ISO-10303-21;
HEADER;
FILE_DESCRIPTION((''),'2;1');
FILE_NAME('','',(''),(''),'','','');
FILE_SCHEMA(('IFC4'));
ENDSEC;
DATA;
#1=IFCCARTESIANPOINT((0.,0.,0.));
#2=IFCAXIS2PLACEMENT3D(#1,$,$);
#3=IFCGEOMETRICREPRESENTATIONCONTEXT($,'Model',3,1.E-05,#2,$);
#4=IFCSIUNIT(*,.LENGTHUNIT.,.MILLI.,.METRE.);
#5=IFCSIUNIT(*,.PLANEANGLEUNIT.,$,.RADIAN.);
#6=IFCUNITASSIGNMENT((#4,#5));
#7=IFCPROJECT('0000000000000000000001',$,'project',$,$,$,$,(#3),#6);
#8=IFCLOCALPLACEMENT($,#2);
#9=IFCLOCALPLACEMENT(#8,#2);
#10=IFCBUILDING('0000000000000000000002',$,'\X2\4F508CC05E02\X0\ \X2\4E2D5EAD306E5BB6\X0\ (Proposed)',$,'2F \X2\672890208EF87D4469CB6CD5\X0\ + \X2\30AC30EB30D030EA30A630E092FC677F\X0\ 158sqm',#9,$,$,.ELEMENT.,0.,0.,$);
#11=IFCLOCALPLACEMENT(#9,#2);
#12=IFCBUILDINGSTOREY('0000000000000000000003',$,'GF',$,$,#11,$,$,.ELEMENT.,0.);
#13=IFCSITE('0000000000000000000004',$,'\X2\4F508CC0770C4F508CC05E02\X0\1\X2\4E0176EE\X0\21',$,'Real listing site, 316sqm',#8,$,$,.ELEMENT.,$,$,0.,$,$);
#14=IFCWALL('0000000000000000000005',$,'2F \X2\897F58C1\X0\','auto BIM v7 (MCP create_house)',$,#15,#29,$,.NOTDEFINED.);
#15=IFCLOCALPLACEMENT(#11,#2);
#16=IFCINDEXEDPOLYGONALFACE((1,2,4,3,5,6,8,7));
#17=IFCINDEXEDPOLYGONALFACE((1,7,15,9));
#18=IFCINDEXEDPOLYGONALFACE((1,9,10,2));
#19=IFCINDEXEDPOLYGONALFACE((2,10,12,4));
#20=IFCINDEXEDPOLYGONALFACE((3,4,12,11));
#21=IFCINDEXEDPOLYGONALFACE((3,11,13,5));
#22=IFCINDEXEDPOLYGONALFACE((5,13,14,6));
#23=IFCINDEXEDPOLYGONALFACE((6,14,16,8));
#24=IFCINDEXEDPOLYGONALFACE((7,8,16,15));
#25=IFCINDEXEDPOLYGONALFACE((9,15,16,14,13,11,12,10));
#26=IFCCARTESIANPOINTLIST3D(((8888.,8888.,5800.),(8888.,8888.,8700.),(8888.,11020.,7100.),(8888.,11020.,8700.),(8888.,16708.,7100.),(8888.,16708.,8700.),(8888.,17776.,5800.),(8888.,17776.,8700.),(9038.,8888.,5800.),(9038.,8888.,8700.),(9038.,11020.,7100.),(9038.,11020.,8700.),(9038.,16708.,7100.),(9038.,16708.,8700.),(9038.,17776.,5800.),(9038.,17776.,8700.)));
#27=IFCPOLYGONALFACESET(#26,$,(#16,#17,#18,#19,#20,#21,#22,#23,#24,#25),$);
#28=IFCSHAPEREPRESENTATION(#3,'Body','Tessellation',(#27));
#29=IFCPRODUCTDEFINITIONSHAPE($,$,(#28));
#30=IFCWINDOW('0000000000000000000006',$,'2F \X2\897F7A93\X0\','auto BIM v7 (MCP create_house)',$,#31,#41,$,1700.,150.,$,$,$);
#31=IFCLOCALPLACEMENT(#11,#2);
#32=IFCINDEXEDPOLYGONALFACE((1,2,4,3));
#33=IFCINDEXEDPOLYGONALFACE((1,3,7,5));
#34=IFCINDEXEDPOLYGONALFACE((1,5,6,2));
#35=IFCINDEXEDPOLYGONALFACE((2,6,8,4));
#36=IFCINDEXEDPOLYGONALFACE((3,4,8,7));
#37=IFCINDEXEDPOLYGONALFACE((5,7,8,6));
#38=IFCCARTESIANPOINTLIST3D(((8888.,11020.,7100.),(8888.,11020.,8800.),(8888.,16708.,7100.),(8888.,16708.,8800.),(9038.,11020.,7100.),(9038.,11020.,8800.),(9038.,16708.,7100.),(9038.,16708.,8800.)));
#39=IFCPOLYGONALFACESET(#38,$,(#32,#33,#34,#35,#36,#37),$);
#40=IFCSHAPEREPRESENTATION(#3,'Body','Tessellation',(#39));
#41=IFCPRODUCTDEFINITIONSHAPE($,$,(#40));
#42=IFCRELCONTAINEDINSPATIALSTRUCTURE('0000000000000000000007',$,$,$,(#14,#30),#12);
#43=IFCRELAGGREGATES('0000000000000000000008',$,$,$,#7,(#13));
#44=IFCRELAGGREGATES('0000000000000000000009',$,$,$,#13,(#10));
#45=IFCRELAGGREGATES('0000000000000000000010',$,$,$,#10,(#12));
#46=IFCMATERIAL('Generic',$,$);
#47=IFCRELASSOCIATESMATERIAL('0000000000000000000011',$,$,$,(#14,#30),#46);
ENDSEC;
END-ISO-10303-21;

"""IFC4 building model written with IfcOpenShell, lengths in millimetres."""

from ifc_helpers import new_model, si_unit, frame, frame_2d, origin, place, context, project, spatial, rectangle, extrude, material, element, fill, save


model = new_model("IFC4")

# Units and contexts
model_context = context("Model", 3, precision=1e-05, world=origin())
ifc_project = project(units=[si_unit("LENGTHUNIT", "METRE", prefix="MILLI"), si_unit("PLANEANGLEUNIT", "RADIAN")], contexts=[model_context])

# Site, building, storey
site_placement = place(None, origin())
site = spatial("IfcSite", under=ifc_project, at=site_placement, Name="佐賀県佐賀市1丁目21", ObjectType="Real listing site, 316sqm", CompositionType="ELEMENT", RefElevation=0.0)
building_placement = place(site_placement, origin())
building = spatial("IfcBuilding", under=site, at=building_placement, Name="佐賀市 中庭の家 (Proposed)", ObjectType="2F 木造軸組構法 + ガルバリウム鋼板 158sqm", CompositionType="ELEMENT", ElevationOfRefHeight=0.0, ElevationOfTerrain=0.0)
storey_placement = place(building_placement, origin())
storey = spatial("IfcBuildingStorey", under=building, at=storey_placement, Name="GF", CompositionType="ELEMENT", Elevation=0.0)

# Shared definitions
ifc_material = material(Name="Generic")

# Wall, opening, window
wall_1_placement = place(storey_placement, frame((4444.0, 4444.0, 2900.0)))
wall_1 = element("IfcWall", 1, at=wall_1_placement, inside=storey, material=ifc_material, Name="2F 西壁", Description="auto BIM v7 (MCP create_house)", PredefinedType="NOTDEFINED", context=model_context, shape_type="SweptSolid", body=[
    extrude(rectangle(XDim=150.0, YDim=8888.0, at=frame_2d((75.0, 4444.0))), frame((4444.0, 4444.0, 2900.0)), (0.0, 0.0, 1.0), 2900.0),
])
opening_1_placement = place(storey_placement, frame((4444.0, 5510.0, 3550.0)))
opening_1 = element("IfcOpeningElement", 2, at=opening_1_placement, cuts=wall_1, PredefinedType="NOTDEFINED", context=model_context, shape_type="SweptSolid", body=[
    extrude(rectangle(XDim=150.0, YDim=5688.0, at=frame_2d((75.0, 2844.0))), frame((4444.0, 5510.0, 3550.0)), (0.0, 0.0, 1.0), 1700.0),
])
window_1_placement = place(storey_placement, frame((4444.0, 5510.0, 3550.0)))
window_1 = element("IfcWindow", 3, at=window_1_placement, inside=storey, material=ifc_material, Name="2F 西窓", Description="auto BIM v7 (MCP create_house)", OverallHeight=1700.0, OverallWidth=150.0, context=model_context, shape_type="SweptSolid", body=[
    extrude(rectangle(XDim=150.0, YDim=5688.0, at=frame_2d((75.0, 2844.0))), frame((4444.0, 5510.0, 3550.0)), (0.0, 0.0, 1.0), 1700.0),
])
fill(opening_1, window_1)

save(model, "model.ifc")
